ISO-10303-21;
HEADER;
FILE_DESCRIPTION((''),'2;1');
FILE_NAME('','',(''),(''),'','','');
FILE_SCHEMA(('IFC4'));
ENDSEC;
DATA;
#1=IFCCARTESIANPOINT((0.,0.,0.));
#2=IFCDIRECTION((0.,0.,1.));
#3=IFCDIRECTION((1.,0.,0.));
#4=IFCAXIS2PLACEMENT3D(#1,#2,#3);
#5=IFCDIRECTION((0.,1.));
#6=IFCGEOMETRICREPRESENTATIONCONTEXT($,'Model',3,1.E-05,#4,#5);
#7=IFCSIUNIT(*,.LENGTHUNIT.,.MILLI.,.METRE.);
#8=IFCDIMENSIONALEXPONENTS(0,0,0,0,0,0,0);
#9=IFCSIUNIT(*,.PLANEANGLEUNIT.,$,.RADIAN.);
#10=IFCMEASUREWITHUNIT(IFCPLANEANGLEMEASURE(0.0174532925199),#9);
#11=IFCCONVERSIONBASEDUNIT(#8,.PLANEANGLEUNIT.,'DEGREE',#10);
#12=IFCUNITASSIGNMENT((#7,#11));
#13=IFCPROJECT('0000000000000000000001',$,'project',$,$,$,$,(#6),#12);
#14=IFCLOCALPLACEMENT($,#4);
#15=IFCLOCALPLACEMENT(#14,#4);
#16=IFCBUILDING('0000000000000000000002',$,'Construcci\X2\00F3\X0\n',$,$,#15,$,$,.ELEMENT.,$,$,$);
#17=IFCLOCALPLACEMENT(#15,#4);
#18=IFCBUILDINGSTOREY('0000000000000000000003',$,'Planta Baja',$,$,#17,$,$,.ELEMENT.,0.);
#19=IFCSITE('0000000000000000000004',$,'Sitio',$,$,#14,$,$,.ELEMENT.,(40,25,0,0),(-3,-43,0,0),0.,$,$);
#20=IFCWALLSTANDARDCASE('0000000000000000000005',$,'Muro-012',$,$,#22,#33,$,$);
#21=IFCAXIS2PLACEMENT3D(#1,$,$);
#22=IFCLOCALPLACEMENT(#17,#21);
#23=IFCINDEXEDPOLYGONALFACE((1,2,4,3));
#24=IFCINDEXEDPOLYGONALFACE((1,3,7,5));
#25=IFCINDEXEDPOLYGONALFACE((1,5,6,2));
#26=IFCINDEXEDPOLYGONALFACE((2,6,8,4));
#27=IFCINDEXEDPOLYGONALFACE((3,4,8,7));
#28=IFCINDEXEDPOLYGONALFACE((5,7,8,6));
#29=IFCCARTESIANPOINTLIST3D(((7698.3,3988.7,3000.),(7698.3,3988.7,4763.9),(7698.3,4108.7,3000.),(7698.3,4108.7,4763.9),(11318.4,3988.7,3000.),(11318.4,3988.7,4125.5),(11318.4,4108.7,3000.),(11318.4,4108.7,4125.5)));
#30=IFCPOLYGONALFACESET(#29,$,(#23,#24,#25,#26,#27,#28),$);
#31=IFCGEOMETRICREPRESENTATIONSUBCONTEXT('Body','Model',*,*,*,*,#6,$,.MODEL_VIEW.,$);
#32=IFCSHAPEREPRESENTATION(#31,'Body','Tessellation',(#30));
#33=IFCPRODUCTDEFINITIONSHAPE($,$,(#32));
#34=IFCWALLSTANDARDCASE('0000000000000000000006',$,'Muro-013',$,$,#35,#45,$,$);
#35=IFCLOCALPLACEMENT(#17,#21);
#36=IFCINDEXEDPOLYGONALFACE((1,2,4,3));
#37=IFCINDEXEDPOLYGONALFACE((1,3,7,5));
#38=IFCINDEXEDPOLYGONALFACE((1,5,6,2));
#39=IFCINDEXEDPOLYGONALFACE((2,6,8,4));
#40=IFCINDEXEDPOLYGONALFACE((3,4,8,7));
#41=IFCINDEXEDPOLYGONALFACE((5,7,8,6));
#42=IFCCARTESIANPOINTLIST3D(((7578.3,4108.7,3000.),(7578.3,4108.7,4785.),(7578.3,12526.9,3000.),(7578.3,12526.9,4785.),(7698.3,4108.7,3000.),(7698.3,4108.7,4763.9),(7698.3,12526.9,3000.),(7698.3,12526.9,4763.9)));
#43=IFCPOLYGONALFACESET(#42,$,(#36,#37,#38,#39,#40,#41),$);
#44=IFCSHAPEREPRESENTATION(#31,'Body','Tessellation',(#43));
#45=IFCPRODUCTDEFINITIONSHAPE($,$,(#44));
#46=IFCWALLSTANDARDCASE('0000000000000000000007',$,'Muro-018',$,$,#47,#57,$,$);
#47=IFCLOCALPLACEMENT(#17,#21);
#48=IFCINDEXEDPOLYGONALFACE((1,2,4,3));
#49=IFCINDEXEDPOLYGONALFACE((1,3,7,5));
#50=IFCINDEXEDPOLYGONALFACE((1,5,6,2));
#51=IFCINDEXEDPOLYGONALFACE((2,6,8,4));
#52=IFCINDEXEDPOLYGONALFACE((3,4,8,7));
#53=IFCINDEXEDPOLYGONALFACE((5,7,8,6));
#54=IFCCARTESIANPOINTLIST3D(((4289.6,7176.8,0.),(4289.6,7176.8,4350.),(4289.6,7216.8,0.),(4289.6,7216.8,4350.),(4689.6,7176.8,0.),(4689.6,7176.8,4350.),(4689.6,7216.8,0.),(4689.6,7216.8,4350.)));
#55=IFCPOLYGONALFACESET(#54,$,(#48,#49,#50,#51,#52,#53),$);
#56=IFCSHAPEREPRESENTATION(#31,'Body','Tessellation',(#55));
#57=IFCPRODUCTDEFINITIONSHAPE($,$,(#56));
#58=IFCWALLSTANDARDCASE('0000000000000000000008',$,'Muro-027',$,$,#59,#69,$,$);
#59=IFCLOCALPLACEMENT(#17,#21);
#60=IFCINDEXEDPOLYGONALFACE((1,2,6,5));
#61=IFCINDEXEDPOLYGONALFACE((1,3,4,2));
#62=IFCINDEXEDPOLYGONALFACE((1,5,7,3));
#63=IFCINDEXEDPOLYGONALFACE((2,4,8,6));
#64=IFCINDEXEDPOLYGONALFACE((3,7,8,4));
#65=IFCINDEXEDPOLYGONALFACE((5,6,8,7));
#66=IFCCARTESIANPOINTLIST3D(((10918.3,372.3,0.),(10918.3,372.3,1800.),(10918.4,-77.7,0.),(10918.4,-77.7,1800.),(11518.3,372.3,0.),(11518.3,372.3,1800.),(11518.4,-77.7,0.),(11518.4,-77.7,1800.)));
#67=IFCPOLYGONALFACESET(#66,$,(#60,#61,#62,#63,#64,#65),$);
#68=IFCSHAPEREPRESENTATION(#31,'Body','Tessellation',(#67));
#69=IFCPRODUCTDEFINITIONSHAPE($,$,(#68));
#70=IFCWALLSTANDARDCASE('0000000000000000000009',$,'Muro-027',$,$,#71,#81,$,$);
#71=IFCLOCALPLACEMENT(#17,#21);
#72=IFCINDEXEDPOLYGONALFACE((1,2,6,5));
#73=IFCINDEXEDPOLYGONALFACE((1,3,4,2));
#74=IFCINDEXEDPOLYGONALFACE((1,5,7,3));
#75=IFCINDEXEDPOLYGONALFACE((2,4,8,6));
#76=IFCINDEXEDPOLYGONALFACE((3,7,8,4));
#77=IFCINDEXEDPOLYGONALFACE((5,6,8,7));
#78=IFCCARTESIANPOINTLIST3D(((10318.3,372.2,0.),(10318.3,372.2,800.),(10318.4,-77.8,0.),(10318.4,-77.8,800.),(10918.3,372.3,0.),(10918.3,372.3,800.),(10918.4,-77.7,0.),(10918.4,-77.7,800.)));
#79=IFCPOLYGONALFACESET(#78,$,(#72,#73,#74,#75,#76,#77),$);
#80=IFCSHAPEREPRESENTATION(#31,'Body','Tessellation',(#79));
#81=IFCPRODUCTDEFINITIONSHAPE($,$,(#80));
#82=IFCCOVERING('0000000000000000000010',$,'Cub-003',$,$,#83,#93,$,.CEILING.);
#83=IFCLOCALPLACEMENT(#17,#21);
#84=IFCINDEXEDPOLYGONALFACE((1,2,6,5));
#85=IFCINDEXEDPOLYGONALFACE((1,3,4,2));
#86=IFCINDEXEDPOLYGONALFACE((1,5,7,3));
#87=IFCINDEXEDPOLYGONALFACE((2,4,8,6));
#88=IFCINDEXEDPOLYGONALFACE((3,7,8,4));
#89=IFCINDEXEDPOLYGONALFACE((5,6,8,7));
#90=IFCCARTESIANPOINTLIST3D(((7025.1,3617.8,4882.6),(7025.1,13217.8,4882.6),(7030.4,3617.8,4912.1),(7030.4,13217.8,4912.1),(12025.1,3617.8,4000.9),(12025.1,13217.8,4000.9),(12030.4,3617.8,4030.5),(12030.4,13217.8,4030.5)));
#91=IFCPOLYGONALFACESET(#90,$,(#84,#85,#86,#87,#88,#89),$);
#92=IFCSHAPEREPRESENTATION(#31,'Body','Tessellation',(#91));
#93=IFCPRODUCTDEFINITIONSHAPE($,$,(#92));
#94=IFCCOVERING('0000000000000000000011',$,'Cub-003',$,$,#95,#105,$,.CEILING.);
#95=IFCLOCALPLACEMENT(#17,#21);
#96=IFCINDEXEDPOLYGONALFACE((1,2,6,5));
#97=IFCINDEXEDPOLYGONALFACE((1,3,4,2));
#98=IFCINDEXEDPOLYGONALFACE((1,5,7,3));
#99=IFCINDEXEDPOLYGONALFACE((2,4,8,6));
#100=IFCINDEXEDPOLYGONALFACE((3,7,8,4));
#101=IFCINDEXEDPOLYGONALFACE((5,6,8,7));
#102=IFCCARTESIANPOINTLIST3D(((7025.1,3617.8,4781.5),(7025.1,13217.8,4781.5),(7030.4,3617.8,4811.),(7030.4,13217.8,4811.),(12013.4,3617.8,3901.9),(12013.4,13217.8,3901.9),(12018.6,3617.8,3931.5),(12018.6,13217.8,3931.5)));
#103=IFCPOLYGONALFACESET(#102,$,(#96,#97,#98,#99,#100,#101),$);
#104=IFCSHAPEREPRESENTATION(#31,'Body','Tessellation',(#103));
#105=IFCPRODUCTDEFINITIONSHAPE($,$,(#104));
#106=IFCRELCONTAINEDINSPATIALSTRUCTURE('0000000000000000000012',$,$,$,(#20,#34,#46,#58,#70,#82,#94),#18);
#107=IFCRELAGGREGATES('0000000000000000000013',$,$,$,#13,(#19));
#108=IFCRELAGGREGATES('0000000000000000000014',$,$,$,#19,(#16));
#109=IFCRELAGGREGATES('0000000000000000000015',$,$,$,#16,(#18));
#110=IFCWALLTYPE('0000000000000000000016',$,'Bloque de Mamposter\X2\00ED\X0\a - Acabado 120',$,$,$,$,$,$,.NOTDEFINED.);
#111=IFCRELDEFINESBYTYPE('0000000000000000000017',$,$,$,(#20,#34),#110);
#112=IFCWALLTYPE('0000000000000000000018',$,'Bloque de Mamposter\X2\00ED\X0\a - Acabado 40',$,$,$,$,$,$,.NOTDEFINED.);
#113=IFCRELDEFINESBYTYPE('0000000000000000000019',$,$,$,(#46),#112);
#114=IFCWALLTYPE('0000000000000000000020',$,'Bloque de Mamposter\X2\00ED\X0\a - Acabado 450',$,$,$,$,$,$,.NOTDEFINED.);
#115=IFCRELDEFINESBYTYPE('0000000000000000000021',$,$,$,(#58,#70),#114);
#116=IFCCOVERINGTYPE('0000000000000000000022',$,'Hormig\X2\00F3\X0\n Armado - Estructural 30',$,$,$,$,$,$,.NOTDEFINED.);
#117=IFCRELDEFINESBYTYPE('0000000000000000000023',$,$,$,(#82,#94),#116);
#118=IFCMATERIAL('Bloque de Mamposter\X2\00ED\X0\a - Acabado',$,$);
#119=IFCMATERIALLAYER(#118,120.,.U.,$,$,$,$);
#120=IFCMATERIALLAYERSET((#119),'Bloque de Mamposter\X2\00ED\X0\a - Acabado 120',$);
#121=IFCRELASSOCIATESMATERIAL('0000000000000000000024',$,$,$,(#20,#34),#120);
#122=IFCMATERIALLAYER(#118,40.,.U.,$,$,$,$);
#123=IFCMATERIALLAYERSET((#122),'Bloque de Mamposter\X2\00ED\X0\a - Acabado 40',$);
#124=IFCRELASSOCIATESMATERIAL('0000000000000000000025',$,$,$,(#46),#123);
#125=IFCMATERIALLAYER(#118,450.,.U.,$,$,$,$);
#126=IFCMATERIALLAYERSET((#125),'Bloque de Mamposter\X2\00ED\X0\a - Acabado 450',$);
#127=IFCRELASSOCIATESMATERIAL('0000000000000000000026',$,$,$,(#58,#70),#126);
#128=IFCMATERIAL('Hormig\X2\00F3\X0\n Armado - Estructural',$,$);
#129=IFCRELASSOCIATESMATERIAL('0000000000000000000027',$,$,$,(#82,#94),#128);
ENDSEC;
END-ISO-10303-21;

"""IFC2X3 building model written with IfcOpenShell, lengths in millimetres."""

from ifc_helpers import new_model, entity, si_unit, converted_unit, direction, frame, origin_with_axes, place, context, subcontext, project, spatial, polyline, outline, extrude, clip, halfspace, material, layer, layer_set, layer_usage, type_object, element, save


model = new_model("IFC2X3")

# Units and contexts
model_context = context("Model", 3, precision=1e-05, world=origin_with_axes(), true_north=direction((0.0, 1.0)))
body_context = subcontext(model_context, "Body", "Model", "MODEL_VIEW")
ifc_project = project(units=[si_unit("LENGTHUNIT", "METRE", prefix="MILLI"), converted_unit("PLANEANGLEUNIT", "DEGREE", entity("IfcPlaneAngleMeasure", 0.0174532925199), si_unit("PLANEANGLEUNIT", "RADIAN"), dimensions=[0, 0, 0, 0, 0, 0, 0])], contexts=[model_context])

# Site, building, storey
site_placement = place(None, origin_with_axes())
site = spatial("IfcSite", under=ifc_project, at=site_placement, Name="Sitio", CompositionType="ELEMENT", RefLatitude=(40, 25, 0, 0), RefLongitude=(-3, -43, 0, 0), RefElevation=0.0)
building_placement = place(site_placement, origin_with_axes())
building = spatial("IfcBuilding", under=site, at=building_placement, Name="Construcción", CompositionType="ELEMENT")
storey_placement = place(building_placement, origin_with_axes())
storey = spatial("IfcBuildingStorey", under=building, at=storey_placement, Name="Planta Baja", CompositionType="ELEMENT", Elevation=0.0)

# Shared definitions
ifc_material_1 = material(Name="Hormigón Armado - Estructural")

# Shared definitions
ifc_material_2 = material(Name="Bloque de Mampostería - Acabado")

# Shared definitions
ifc_layer_1 = layer(ifc_material_2, 120.0, ventilated="UNKNOWN")
ifc_layer_set_1 = layer_set([ifc_layer_1], Name="Bloque de Mampostería - Acabado 120")
wall_type_1 = type_object("IfcWallType", Name="Bloque de Mampostería - Acabado 120", PredefinedType="NOTDEFINED")

# Walls
ifc_layer_usage_1 = layer_usage(ifc_layer_set_1, "AXIS2", "POSITIVE", 0.0)
wall_1_placement = place(storey_placement, frame((11318.4, 4108.7, 3000.0), z_axis=(0.0, 0.0, 1.0), x_axis=(-1.0, 0.0, 0.0)))
element("IfcWallStandardCase", 1, at=wall_1_placement, inside=storey, type_object=wall_type_1, material=ifc_layer_usage_1, Name="Muro-012", context=body_context, shape_type="Clipping", body=[
    clip(extrude(outline(polyline([(0.0, 0.0), (3620.1, 0.0), (3620.1, 120.0), (0.0, 120.0), (0.0, 0.0)])), origin_with_axes(), (0.0, 0.0, 1.0), 5000.0), halfspace(frame((-192.5, 0.0, 1091.6), z_axis=(0.173648, 0.0, -0.984808), x_axis=(0.0, 1.0, 0.0)), True)),
])
ifc_layer_usage_2 = layer_usage(ifc_layer_set_1, "AXIS2", "POSITIVE", 0.0)
wall_2_placement = place(storey_placement, frame((7698.3, 4108.7, 3000.0), z_axis=(0.0, 0.0, 1.0), x_axis=(-0.000002, 1.0, 0.0)))
element("IfcWallStandardCase", 2, at=wall_2_placement, inside=storey, type_object=wall_type_1, material=ifc_layer_usage_2, Name="Muro-013", context=body_context, shape_type="Clipping", body=[
    clip(extrude(outline(polyline([(0.0, 0.0), (8418.2, 0.0), (8418.2, 120.0), (0.0, 120.0), (0.0, 0.0)])), origin_with_axes(), (0.0, 0.0, 1.0), 5000.0), halfspace(frame((0.0, -301.6, 1710.7), z_axis=(0.0, 0.173648, -0.984808), x_axis=(0.0, 0.984808, 0.173648)), True)),
])

# Walls
ifc_layer_2 = layer(ifc_material_2, 40.0, ventilated="UNKNOWN")
ifc_layer_set_2 = layer_set([ifc_layer_2], Name="Bloque de Mampostería - Acabado 40")
ifc_layer_usage_3 = layer_usage(ifc_layer_set_2, "AXIS2", "POSITIVE", -40.0)
wall_type_2 = type_object("IfcWallType", Name="Bloque de Mampostería - Acabado 40", PredefinedType="NOTDEFINED")
wall_3_placement = place(storey_placement, frame((4289.6, 7216.8, 0.0), z_axis=(0.0, 0.0, 1.0), x_axis=(1.0, 0.0, 0.0)))
element("IfcWallStandardCase", 3, at=wall_3_placement, inside=storey, type_object=wall_type_2, material=ifc_layer_usage_3, Name="Muro-018", context=body_context, shape_type="SweptSolid", body=[
    extrude(outline(polyline([(0.0, -40.0), (400.0, -40.0), (400.0, 0.0), (0.0, 0.0), (0.0, -40.0)])), origin_with_axes(), (0.0, 0.0, 1.0), 4350.0),
])
ifc_layer_3 = layer(ifc_material_2, 450.0, ventilated="UNKNOWN")
ifc_layer_set_3 = layer_set([ifc_layer_3], Name="Bloque de Mampostería - Acabado 450")
ifc_layer_usage_4 = layer_usage(ifc_layer_set_3, "AXIS2", "POSITIVE", 0.0)
wall_type_3 = type_object("IfcWallType", Name="Bloque de Mampostería - Acabado 450", PredefinedType="NOTDEFINED")
wall_4_placement = place(storey_placement, frame((10918.4, -77.7, 0.0), z_axis=(0.0, 0.0, 1.0), x_axis=(1.0, 0.000068, 0.0)))
element("IfcWallStandardCase", 4, at=wall_4_placement, inside=storey, type_object=wall_type_3, material=ifc_layer_usage_4, Name="Muro-027", context=body_context, shape_type="SweptSolid", body=[
    extrude(outline(polyline([(0.0, 0.0), (600.0, 0.0), (600.0, 450.0), (0.0, 450.0), (0.0, 0.0)])), origin_with_axes(), (0.0, 0.0, 1.0), 1800.0),
])
ifc_layer_usage_5 = layer_usage(ifc_layer_set_3, "AXIS2", "POSITIVE", 0.0)
wall_5_placement = place(storey_placement, frame((10318.4, -77.8, 0.0), z_axis=(0.0, 0.0, 1.0), x_axis=(1.0, 0.000068, 0.0)))
element("IfcWallStandardCase", 5, at=wall_5_placement, inside=storey, type_object=wall_type_3, material=ifc_layer_usage_5, Name="Muro-027", context=body_context, shape_type="SweptSolid", body=[
    extrude(outline(polyline([(0.0, 0.0), (600.0, 0.0), (600.0, 450.0), (0.0, 450.0), (0.0, 0.0)])), origin_with_axes(), (0.0, 0.0, 1.0), 800.0),
])

# Coverings
covering_type = type_object("IfcCoveringType", Name="Hormigón Armado - Estructural 30", PredefinedType="NOTDEFINED")
covering_1_placement = place(storey_placement, frame((12030.4, 3617.8, 4000.0), z_axis=(0.0, 0.0, 1.0), x_axis=(0.0, 1.0, 0.0)))
element("IfcCovering", 6, at=covering_1_placement, inside=storey, type_object=covering_type, material=ifc_material_1, Name="Cub-003", PredefinedType="CEILING", context=body_context, shape_type="SweptSolid", body=[
    extrude(outline(polyline([(9600.0, 5.3), (9600.0, 5082.4), (0.0, 5082.4), (0.0, 5.3), (9600.0, 5.3)])), frame((0.0, 0.0, 0.0), z_axis=(0.0, -0.173648, 0.984808), x_axis=(1.0, 0.0, 0.0)), (0.0, 0.0, 1.0), 30.0),
])
covering_2_placement = place(storey_placement, frame((12018.6, 3617.8, 3901.0), z_axis=(0.0, 0.0, 1.0), x_axis=(0.0, 1.0, 0.0)))
element("IfcCovering", 7, at=covering_2_placement, inside=storey, type_object=covering_type, material=ifc_material_1, Name="Cub-003", PredefinedType="CEILING", context=body_context, shape_type="SweptSolid", body=[
    extrude(outline(polyline([(9600.0, 5.3), (9600.0, 5070.5), (0.0, 5070.5), (0.0, 5.3), (9600.0, 5.3)])), frame((0.0, 0.0, 0.0), z_axis=(0.0, -0.173648, 0.984808), x_axis=(1.0, 0.0, 0.0)), (0.0, 0.0, 1.0), 30.0),
])

save(model, "model.ifc")
